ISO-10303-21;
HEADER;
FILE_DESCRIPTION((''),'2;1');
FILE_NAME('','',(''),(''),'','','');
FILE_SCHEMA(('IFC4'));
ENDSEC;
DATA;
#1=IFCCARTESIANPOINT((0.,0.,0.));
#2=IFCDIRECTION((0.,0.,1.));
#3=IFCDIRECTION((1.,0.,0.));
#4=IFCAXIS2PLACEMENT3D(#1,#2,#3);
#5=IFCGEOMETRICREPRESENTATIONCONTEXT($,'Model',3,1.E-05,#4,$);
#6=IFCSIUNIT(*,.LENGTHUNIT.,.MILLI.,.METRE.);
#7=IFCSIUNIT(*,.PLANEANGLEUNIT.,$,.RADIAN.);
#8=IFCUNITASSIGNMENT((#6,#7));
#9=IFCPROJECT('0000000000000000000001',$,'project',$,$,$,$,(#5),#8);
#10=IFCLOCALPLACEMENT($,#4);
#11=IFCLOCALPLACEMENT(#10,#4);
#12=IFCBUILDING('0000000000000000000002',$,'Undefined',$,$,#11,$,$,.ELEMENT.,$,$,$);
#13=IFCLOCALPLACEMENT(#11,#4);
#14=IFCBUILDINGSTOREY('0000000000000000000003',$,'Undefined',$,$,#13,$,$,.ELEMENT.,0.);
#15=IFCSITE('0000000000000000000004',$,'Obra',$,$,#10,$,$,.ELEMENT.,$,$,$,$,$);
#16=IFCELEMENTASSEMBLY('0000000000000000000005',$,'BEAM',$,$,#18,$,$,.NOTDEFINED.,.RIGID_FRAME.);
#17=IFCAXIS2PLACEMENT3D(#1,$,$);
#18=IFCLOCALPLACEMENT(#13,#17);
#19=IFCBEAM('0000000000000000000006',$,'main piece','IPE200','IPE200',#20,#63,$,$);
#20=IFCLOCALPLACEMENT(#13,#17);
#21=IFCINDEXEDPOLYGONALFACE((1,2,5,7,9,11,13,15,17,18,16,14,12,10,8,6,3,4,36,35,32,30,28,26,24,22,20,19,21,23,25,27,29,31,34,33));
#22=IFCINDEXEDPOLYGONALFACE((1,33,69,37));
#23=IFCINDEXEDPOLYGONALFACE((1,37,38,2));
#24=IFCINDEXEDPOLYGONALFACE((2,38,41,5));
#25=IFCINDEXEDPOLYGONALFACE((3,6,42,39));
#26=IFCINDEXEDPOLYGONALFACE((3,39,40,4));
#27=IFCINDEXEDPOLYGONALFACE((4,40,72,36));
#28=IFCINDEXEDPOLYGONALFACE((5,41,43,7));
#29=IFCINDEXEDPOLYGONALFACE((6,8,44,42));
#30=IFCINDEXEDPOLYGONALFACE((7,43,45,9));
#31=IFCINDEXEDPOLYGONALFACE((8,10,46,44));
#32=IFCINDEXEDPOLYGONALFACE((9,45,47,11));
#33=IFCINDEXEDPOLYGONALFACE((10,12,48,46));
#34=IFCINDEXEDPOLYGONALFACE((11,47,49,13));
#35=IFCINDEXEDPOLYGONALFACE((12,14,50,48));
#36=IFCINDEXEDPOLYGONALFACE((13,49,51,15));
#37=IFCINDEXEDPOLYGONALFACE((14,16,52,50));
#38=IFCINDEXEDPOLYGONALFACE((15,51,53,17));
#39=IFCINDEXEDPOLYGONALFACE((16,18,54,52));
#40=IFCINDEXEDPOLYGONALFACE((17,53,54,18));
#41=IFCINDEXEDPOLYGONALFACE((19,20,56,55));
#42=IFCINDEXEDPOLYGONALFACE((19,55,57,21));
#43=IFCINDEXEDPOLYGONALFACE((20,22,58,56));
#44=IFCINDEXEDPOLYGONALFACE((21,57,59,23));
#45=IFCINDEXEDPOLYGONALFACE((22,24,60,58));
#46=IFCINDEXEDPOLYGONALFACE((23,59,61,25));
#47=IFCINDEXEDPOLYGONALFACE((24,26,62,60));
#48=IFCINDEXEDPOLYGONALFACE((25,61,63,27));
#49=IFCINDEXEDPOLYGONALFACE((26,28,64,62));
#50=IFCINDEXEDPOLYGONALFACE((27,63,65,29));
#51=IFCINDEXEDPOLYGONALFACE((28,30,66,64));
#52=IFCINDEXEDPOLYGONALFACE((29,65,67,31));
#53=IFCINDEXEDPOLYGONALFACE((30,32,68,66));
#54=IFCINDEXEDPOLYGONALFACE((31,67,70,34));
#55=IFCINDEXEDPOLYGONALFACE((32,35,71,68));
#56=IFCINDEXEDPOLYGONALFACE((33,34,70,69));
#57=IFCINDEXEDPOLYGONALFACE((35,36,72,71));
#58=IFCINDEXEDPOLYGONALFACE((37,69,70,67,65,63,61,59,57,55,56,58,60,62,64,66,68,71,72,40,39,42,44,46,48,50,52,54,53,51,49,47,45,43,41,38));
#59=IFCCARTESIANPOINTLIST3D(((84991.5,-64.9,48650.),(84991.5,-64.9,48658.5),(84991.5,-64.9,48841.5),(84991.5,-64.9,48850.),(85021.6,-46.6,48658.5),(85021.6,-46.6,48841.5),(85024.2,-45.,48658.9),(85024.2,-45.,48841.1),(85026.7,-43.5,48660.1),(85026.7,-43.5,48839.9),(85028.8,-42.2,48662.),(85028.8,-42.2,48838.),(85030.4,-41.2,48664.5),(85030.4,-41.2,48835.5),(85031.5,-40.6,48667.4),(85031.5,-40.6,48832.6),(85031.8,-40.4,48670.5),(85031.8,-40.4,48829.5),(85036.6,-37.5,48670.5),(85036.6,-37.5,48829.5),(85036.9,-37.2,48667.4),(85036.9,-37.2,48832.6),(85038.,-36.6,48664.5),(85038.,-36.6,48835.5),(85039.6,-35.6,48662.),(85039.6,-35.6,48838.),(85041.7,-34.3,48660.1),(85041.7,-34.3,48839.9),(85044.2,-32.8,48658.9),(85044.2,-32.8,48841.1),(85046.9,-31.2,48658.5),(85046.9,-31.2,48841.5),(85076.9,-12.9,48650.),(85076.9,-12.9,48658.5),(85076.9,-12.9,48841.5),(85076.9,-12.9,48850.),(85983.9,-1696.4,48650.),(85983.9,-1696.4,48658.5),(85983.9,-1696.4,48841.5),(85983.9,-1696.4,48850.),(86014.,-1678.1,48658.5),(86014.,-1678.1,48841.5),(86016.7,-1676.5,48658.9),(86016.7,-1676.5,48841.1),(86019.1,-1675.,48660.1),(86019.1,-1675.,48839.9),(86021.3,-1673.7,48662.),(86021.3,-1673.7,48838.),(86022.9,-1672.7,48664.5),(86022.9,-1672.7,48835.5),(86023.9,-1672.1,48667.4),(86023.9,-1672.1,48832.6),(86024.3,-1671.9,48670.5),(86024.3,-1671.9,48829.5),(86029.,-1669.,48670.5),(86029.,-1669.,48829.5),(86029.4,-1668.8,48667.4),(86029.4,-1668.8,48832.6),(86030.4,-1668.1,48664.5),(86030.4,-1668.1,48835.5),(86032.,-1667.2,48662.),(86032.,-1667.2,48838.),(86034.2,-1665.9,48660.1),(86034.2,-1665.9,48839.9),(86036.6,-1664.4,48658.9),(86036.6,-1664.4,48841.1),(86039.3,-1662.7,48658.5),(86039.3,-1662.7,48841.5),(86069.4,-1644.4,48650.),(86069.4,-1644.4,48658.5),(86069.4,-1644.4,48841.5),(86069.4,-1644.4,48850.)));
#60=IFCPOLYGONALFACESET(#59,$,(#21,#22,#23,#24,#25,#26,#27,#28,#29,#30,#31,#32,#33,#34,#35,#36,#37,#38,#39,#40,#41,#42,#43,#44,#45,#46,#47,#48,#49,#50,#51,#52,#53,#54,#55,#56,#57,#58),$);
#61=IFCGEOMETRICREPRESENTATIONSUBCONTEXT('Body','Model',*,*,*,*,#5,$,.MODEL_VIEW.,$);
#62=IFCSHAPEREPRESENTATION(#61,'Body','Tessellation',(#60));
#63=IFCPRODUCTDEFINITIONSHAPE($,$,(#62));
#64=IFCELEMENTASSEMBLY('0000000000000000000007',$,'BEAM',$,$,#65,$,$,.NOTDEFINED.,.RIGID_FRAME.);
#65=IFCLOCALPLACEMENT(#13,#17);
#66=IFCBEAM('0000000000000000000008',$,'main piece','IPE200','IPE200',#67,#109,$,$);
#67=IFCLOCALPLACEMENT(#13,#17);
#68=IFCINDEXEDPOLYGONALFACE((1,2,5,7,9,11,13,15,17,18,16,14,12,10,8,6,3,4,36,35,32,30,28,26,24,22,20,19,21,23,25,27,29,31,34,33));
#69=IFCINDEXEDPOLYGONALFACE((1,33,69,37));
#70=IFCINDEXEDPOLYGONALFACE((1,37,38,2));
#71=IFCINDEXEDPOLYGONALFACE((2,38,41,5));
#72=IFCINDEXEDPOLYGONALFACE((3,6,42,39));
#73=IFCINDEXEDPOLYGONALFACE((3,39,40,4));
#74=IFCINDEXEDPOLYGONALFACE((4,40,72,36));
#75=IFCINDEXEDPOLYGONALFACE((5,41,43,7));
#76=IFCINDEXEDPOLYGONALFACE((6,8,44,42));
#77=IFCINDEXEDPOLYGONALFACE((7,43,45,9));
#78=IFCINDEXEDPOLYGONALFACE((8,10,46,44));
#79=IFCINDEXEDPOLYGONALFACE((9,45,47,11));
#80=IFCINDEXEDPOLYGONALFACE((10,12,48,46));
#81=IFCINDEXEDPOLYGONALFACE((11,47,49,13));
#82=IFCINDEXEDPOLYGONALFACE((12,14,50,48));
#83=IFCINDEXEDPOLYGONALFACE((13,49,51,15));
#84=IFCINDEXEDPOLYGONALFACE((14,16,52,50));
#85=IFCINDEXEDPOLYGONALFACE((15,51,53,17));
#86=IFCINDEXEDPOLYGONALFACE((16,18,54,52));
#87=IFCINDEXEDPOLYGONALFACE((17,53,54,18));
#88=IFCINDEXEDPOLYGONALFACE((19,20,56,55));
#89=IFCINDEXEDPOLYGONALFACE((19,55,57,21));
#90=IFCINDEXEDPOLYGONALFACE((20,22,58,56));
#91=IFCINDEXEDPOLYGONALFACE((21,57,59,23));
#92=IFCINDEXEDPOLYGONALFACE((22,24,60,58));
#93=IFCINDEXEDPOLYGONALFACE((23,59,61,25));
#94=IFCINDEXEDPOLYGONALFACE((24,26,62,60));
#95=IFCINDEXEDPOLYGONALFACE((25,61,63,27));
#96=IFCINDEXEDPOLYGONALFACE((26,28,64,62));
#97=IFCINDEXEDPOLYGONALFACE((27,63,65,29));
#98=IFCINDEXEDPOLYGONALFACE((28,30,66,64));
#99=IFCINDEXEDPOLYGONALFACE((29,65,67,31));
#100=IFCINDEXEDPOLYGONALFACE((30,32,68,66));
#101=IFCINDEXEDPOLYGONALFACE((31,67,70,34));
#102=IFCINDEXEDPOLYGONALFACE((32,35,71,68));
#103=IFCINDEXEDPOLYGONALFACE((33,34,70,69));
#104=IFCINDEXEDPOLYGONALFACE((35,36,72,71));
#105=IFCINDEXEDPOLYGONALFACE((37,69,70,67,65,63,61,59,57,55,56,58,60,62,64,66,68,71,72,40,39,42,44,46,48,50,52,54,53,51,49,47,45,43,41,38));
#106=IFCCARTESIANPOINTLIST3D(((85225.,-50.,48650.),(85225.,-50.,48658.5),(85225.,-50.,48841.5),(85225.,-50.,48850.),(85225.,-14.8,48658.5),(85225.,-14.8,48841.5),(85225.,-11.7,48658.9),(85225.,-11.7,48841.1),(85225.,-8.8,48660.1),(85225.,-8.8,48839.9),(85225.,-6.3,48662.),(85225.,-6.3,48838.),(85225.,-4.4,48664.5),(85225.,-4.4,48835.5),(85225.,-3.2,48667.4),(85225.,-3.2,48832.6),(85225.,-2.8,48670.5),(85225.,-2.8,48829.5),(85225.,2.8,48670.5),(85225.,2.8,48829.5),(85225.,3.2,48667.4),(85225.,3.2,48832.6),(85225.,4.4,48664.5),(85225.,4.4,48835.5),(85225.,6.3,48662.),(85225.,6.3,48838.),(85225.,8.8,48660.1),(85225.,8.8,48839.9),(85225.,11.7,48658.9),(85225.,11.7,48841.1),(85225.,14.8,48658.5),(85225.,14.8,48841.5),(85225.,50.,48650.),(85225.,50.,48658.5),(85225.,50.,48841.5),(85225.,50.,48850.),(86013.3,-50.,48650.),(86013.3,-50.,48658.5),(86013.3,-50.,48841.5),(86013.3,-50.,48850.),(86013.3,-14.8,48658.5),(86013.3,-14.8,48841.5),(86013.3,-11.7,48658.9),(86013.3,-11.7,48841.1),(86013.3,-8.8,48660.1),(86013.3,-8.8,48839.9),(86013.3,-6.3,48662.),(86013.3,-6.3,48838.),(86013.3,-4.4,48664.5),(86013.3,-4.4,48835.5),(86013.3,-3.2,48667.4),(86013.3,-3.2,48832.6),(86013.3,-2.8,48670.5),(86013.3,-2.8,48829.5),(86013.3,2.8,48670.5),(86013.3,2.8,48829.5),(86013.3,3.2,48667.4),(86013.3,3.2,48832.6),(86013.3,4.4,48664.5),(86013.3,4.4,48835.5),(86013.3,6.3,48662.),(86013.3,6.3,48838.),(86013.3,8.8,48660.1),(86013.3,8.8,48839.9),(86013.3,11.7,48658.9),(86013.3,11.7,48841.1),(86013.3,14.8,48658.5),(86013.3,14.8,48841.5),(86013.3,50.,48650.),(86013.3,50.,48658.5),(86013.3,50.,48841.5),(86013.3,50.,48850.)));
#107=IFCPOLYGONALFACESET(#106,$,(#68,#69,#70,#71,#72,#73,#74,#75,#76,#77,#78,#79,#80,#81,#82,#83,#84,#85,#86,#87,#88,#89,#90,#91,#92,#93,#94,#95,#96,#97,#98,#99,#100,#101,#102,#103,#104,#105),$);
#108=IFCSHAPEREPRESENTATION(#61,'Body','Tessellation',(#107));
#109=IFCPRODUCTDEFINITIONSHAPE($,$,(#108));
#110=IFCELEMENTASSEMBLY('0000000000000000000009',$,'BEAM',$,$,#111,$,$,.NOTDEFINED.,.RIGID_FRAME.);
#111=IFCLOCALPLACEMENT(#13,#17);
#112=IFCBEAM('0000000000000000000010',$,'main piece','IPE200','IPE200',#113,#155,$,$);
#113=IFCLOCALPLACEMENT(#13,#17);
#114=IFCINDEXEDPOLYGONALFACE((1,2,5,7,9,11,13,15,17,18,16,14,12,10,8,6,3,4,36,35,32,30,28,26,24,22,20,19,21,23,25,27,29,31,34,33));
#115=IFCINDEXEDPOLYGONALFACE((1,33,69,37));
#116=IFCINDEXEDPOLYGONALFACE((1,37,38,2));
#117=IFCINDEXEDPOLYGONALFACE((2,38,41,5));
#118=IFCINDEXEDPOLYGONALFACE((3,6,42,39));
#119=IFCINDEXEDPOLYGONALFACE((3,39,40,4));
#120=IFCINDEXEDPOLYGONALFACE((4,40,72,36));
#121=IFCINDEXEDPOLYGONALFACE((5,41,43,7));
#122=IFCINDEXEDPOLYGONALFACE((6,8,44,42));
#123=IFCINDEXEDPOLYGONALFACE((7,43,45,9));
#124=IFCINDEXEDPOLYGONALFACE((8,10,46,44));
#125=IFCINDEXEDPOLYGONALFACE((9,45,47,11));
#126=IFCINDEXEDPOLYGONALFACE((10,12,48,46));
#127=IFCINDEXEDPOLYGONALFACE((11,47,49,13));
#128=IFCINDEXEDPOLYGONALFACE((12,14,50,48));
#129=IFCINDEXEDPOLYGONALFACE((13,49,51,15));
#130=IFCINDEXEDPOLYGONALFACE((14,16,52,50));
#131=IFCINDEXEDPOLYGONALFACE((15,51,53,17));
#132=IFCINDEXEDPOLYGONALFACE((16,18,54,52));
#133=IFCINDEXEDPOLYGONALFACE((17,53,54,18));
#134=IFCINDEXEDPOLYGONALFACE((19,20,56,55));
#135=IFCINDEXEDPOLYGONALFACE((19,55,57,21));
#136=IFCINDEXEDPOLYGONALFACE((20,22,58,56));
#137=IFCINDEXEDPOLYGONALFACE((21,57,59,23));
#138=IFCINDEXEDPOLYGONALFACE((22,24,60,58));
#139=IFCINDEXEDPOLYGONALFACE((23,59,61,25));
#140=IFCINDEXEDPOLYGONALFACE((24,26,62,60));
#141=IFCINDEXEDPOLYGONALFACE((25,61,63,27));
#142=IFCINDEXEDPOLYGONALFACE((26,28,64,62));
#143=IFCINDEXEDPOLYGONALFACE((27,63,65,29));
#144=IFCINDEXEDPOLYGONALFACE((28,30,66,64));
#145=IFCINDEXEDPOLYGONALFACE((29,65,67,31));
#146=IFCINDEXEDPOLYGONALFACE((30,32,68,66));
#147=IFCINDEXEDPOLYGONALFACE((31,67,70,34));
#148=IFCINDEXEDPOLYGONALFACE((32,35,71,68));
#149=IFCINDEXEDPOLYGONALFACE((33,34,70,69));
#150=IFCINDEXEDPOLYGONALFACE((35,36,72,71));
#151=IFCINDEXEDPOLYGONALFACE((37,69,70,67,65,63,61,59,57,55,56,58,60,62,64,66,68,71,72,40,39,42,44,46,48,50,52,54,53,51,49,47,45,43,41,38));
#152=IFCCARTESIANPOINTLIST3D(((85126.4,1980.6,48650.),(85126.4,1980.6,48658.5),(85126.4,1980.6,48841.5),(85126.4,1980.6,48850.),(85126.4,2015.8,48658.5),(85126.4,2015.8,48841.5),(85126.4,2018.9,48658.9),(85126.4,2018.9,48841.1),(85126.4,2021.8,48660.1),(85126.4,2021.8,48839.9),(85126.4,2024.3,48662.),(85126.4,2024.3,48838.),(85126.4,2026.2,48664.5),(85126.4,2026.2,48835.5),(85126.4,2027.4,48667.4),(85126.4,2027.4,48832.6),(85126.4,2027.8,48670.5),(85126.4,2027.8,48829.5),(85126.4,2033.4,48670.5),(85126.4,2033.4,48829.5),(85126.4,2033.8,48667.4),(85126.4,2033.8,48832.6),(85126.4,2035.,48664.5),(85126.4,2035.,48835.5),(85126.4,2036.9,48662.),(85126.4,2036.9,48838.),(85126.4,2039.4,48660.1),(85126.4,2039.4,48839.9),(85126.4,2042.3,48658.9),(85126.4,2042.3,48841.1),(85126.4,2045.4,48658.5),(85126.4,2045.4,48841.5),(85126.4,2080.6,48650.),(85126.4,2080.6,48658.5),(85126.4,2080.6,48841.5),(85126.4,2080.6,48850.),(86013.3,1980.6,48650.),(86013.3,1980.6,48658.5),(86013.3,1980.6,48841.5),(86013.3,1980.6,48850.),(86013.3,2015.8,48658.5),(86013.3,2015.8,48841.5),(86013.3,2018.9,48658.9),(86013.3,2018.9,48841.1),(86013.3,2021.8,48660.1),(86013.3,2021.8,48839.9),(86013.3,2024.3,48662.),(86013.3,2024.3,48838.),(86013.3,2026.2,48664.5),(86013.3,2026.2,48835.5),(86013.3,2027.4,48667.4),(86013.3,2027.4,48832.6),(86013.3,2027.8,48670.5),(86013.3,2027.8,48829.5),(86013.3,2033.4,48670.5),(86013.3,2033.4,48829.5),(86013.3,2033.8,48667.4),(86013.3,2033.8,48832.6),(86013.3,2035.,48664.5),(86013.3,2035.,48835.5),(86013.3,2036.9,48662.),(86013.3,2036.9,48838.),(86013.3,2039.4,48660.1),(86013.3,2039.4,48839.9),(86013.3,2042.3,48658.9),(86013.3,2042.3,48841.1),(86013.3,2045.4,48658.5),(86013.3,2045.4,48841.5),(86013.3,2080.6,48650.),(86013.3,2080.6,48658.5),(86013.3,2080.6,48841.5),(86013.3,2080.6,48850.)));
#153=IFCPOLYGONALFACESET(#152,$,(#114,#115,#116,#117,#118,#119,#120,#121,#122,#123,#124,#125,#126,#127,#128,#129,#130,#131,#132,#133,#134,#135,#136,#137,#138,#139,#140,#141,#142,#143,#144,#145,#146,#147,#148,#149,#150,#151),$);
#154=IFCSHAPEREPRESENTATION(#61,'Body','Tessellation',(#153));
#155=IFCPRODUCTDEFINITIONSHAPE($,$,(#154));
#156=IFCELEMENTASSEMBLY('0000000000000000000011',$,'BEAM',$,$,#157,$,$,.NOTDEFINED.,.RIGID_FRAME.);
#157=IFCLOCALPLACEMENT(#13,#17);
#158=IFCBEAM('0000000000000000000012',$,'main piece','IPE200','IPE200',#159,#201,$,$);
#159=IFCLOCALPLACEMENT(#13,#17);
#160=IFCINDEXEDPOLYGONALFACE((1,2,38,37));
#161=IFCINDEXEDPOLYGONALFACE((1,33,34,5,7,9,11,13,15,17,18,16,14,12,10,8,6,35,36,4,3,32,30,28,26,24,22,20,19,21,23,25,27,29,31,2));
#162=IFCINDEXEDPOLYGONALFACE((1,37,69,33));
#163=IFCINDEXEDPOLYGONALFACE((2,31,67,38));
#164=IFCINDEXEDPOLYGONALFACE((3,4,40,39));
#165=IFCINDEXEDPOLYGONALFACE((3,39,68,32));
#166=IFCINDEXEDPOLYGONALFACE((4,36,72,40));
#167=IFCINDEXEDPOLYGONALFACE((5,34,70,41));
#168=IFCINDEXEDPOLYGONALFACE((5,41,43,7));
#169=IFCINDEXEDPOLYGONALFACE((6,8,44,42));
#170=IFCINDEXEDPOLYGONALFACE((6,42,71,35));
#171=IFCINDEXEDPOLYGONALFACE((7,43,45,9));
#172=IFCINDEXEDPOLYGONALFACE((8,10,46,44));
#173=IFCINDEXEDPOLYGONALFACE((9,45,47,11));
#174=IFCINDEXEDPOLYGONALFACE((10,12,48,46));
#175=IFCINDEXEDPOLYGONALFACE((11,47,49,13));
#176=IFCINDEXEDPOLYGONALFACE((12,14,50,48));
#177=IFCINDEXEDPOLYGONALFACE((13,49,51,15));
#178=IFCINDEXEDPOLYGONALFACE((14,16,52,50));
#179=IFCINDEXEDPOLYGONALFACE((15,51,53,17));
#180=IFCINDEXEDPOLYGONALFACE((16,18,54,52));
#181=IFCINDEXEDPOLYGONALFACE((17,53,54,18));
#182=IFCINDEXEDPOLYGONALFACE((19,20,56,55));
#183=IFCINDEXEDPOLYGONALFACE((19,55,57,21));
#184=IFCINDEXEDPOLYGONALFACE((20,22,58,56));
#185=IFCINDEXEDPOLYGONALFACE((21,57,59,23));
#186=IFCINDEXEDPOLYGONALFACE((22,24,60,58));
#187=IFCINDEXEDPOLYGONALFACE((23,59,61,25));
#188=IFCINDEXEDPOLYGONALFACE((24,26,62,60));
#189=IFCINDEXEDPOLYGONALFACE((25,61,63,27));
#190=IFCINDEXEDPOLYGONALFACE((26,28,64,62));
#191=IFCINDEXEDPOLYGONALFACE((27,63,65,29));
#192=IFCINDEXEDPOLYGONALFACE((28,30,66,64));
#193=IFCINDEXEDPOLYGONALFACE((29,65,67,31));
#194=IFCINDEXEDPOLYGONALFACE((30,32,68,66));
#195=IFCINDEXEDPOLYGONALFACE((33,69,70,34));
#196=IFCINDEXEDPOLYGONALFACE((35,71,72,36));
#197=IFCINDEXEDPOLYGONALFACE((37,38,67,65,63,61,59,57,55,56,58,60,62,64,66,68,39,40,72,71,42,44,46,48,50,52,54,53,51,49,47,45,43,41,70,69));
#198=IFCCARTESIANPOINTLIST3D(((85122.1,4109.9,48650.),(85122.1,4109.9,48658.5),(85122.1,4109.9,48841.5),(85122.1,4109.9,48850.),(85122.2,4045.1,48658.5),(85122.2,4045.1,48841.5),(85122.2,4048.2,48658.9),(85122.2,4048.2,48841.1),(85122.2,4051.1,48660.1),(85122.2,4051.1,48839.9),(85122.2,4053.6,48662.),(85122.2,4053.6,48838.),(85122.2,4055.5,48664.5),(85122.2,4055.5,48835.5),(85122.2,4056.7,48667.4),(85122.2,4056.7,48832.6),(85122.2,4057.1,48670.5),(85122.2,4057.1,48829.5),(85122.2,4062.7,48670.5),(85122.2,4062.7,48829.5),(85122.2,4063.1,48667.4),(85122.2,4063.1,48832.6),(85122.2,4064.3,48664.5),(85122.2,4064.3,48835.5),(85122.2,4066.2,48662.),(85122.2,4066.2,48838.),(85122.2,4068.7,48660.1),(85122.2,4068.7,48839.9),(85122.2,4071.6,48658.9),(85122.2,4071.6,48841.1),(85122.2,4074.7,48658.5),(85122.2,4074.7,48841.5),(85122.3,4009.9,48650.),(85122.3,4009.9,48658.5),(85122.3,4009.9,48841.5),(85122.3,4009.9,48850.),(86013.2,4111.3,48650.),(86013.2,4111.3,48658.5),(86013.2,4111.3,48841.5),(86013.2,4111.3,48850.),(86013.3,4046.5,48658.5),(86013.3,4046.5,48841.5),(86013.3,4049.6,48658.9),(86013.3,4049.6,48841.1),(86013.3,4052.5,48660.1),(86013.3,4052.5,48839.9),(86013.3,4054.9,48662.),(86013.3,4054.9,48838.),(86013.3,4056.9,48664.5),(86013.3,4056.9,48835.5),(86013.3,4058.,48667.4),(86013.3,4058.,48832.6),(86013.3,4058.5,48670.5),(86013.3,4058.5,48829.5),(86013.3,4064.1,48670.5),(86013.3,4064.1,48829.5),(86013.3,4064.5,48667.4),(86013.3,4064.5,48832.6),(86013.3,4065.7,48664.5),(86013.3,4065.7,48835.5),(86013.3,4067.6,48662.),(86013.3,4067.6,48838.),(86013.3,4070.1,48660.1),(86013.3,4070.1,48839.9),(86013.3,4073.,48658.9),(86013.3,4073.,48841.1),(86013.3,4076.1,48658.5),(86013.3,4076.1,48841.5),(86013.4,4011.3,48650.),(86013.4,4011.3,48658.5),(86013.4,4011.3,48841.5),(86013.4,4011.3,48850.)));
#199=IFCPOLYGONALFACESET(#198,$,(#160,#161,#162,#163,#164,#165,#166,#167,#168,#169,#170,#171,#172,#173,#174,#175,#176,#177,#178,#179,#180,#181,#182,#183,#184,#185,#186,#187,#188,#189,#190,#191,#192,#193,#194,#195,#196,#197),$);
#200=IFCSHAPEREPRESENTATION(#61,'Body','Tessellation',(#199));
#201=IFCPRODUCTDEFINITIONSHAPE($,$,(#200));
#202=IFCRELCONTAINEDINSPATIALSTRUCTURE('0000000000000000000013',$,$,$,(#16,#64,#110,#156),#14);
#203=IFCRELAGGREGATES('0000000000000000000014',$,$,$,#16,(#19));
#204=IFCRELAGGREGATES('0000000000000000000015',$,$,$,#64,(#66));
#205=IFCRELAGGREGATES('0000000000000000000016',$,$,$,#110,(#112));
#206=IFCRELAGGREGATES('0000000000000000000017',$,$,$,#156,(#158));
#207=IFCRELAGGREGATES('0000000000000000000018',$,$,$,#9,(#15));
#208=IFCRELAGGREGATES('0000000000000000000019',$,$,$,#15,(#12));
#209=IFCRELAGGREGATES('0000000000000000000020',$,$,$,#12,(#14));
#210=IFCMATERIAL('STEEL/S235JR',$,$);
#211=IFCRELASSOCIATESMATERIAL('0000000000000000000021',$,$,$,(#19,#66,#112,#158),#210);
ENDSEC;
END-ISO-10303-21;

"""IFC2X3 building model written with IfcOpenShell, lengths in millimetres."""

from ifc_helpers import new_model, si_unit, frame, origin_with_axes, origin_2d_with_axis, place, context, subcontext, project, spatial, i_section, extrude, material, element, aggregate, save


model = new_model("IFC2X3")

# Units and contexts
model_context = context("Model", 3, precision=1e-05, world=origin_with_axes())
body_context = subcontext(model_context, "Body", "Model", "MODEL_VIEW")
ifc_project = project(units=[si_unit("LENGTHUNIT", "METRE", prefix="MILLI"), si_unit("PLANEANGLEUNIT", "RADIAN")], contexts=[model_context])

# Site, building, storey
site_placement = place(None, origin_with_axes())
site = spatial("IfcSite", under=ifc_project, at=site_placement, Name="Obra", CompositionType="ELEMENT")
building_placement = place(site_placement, origin_with_axes())
building = spatial("IfcBuilding", under=site, at=building_placement, Name="Undefined", CompositionType="ELEMENT")
storey_placement = place(building_placement, origin_with_axes())
storey = spatial("IfcBuildingStorey", under=building, at=storey_placement, Name="Undefined", CompositionType="ELEMENT", Elevation=0.0)

# Shared definitions
ifc_material_1 = material(Name="STEEL/S235JR")

# Element assemblies, beams
assembly_1_placement = place(storey_placement, origin_with_axes())
assembly_1 = element("IfcElementAssembly", 1, at=assembly_1_placement, inside=storey, Name="BEAM", AssemblyPlace="NOTDEFINED", PredefinedType="RIGID_FRAME")
beam_1_placement = place(assembly_1_placement, frame((85034.2, -38.9, 48750.0), z_axis=(0.0, 0.0, 1.0), x_axis=(0.519695, -0.854352, 0.0)))
beam_1 = element("IfcBeam", 2, at=beam_1_placement, material=ifc_material_1, Name="main piece", Description="IPE200", ObjectType="IPE200", context=body_context, shape_type="SweptSolid", body=[
    extrude(i_section(OverallWidth=100.0, OverallDepth=200.0, WebThickness=5.6, FlangeThickness=8.5, FilletRadius=12.0, at=origin_2d_with_axis()), frame((1909.7, 0.0, 0.0), z_axis=(-1.0, 0.0, 0.0), x_axis=(0.0, -1.0, 0.0)), (0.0, 0.0, 1.0), 1909.7),
])
aggregate(assembly_1, [beam_1])
assembly_2_placement = place(storey_placement, origin_with_axes())
assembly_2 = element("IfcElementAssembly", 3, at=assembly_2_placement, inside=storey, Name="BEAM", AssemblyPlace="NOTDEFINED", PredefinedType="RIGID_FRAME")
beam_2_placement = place(assembly_2_placement, frame((85225.0, 0.0, 48750.0), z_axis=(0.0, 0.0, 1.0), x_axis=(1.0, 0.0, 0.0)))
beam_2 = element("IfcBeam", 4, at=beam_2_placement, material=ifc_material_1, Name="main piece", Description="IPE200", ObjectType="IPE200", context=body_context, shape_type="SweptSolid", body=[
    extrude(i_section(OverallWidth=100.0, OverallDepth=200.0, WebThickness=5.6, FlangeThickness=8.5, FilletRadius=12.0, at=origin_2d_with_axis()), frame((788.3, 0.0, 0.0), z_axis=(-1.0, 0.0, 0.0), x_axis=(0.0, -1.0, 0.0)), (0.0, 0.0, 1.0), 788.3),
])
aggregate(assembly_2, [beam_2])
assembly_3_placement = place(storey_placement, origin_with_axes())
assembly_3 = element("IfcElementAssembly", 5, at=assembly_3_placement, inside=storey, Name="BEAM", AssemblyPlace="NOTDEFINED", PredefinedType="RIGID_FRAME")
beam_3_placement = place(assembly_3_placement, frame((85126.4, 2030.6, 48750.0), z_axis=(0.0, 0.0, 1.0), x_axis=(1.0, 0.0, 0.0)))
beam_3 = element("IfcBeam", 6, at=beam_3_placement, material=ifc_material_1, Name="main piece", Description="IPE200", ObjectType="IPE200", context=body_context, shape_type="SweptSolid", body=[
    extrude(i_section(OverallWidth=100.0, OverallDepth=200.0, WebThickness=5.6, FlangeThickness=8.5, FilletRadius=12.0, at=origin_2d_with_axis()), frame((886.9, 0.0, 0.0), z_axis=(-1.0, 0.0, 0.0), x_axis=(0.0, -1.0, 0.0)), (0.0, 0.0, 1.0), 886.9),
])
aggregate(assembly_3, [beam_3])
assembly_4_placement = place(storey_placement, origin_with_axes())
assembly_4 = element("IfcElementAssembly", 7, at=assembly_4_placement, inside=storey, Name="BEAM", AssemblyPlace="NOTDEFINED", PredefinedType="RIGID_FRAME")
beam_4_placement = place(assembly_4_placement, frame((85122.2, 4059.9, 48750.0), z_axis=(0.0, 0.0, 1.0), x_axis=(0.999999, 0.001525, 0.0)))
beam_4 = element("IfcBeam", 8, at=beam_4_placement, material=ifc_material_1, Name="main piece", Description="IPE200", ObjectType="IPE200", context=body_context, shape_type="SweptSolid", body=[
    extrude(i_section(OverallWidth=100.0, OverallDepth=200.0, WebThickness=5.6, FlangeThickness=8.5, FilletRadius=12.0, at=origin_2d_with_axis()), frame((891.1, 0.0, 0.0), z_axis=(-1.0, 0.0, 0.0), x_axis=(0.0, -1.0, 0.0)), (0.0, 0.0, 1.0), 891.1),
])
aggregate(assembly_4, [beam_4])

save(model, "model.ifc")
